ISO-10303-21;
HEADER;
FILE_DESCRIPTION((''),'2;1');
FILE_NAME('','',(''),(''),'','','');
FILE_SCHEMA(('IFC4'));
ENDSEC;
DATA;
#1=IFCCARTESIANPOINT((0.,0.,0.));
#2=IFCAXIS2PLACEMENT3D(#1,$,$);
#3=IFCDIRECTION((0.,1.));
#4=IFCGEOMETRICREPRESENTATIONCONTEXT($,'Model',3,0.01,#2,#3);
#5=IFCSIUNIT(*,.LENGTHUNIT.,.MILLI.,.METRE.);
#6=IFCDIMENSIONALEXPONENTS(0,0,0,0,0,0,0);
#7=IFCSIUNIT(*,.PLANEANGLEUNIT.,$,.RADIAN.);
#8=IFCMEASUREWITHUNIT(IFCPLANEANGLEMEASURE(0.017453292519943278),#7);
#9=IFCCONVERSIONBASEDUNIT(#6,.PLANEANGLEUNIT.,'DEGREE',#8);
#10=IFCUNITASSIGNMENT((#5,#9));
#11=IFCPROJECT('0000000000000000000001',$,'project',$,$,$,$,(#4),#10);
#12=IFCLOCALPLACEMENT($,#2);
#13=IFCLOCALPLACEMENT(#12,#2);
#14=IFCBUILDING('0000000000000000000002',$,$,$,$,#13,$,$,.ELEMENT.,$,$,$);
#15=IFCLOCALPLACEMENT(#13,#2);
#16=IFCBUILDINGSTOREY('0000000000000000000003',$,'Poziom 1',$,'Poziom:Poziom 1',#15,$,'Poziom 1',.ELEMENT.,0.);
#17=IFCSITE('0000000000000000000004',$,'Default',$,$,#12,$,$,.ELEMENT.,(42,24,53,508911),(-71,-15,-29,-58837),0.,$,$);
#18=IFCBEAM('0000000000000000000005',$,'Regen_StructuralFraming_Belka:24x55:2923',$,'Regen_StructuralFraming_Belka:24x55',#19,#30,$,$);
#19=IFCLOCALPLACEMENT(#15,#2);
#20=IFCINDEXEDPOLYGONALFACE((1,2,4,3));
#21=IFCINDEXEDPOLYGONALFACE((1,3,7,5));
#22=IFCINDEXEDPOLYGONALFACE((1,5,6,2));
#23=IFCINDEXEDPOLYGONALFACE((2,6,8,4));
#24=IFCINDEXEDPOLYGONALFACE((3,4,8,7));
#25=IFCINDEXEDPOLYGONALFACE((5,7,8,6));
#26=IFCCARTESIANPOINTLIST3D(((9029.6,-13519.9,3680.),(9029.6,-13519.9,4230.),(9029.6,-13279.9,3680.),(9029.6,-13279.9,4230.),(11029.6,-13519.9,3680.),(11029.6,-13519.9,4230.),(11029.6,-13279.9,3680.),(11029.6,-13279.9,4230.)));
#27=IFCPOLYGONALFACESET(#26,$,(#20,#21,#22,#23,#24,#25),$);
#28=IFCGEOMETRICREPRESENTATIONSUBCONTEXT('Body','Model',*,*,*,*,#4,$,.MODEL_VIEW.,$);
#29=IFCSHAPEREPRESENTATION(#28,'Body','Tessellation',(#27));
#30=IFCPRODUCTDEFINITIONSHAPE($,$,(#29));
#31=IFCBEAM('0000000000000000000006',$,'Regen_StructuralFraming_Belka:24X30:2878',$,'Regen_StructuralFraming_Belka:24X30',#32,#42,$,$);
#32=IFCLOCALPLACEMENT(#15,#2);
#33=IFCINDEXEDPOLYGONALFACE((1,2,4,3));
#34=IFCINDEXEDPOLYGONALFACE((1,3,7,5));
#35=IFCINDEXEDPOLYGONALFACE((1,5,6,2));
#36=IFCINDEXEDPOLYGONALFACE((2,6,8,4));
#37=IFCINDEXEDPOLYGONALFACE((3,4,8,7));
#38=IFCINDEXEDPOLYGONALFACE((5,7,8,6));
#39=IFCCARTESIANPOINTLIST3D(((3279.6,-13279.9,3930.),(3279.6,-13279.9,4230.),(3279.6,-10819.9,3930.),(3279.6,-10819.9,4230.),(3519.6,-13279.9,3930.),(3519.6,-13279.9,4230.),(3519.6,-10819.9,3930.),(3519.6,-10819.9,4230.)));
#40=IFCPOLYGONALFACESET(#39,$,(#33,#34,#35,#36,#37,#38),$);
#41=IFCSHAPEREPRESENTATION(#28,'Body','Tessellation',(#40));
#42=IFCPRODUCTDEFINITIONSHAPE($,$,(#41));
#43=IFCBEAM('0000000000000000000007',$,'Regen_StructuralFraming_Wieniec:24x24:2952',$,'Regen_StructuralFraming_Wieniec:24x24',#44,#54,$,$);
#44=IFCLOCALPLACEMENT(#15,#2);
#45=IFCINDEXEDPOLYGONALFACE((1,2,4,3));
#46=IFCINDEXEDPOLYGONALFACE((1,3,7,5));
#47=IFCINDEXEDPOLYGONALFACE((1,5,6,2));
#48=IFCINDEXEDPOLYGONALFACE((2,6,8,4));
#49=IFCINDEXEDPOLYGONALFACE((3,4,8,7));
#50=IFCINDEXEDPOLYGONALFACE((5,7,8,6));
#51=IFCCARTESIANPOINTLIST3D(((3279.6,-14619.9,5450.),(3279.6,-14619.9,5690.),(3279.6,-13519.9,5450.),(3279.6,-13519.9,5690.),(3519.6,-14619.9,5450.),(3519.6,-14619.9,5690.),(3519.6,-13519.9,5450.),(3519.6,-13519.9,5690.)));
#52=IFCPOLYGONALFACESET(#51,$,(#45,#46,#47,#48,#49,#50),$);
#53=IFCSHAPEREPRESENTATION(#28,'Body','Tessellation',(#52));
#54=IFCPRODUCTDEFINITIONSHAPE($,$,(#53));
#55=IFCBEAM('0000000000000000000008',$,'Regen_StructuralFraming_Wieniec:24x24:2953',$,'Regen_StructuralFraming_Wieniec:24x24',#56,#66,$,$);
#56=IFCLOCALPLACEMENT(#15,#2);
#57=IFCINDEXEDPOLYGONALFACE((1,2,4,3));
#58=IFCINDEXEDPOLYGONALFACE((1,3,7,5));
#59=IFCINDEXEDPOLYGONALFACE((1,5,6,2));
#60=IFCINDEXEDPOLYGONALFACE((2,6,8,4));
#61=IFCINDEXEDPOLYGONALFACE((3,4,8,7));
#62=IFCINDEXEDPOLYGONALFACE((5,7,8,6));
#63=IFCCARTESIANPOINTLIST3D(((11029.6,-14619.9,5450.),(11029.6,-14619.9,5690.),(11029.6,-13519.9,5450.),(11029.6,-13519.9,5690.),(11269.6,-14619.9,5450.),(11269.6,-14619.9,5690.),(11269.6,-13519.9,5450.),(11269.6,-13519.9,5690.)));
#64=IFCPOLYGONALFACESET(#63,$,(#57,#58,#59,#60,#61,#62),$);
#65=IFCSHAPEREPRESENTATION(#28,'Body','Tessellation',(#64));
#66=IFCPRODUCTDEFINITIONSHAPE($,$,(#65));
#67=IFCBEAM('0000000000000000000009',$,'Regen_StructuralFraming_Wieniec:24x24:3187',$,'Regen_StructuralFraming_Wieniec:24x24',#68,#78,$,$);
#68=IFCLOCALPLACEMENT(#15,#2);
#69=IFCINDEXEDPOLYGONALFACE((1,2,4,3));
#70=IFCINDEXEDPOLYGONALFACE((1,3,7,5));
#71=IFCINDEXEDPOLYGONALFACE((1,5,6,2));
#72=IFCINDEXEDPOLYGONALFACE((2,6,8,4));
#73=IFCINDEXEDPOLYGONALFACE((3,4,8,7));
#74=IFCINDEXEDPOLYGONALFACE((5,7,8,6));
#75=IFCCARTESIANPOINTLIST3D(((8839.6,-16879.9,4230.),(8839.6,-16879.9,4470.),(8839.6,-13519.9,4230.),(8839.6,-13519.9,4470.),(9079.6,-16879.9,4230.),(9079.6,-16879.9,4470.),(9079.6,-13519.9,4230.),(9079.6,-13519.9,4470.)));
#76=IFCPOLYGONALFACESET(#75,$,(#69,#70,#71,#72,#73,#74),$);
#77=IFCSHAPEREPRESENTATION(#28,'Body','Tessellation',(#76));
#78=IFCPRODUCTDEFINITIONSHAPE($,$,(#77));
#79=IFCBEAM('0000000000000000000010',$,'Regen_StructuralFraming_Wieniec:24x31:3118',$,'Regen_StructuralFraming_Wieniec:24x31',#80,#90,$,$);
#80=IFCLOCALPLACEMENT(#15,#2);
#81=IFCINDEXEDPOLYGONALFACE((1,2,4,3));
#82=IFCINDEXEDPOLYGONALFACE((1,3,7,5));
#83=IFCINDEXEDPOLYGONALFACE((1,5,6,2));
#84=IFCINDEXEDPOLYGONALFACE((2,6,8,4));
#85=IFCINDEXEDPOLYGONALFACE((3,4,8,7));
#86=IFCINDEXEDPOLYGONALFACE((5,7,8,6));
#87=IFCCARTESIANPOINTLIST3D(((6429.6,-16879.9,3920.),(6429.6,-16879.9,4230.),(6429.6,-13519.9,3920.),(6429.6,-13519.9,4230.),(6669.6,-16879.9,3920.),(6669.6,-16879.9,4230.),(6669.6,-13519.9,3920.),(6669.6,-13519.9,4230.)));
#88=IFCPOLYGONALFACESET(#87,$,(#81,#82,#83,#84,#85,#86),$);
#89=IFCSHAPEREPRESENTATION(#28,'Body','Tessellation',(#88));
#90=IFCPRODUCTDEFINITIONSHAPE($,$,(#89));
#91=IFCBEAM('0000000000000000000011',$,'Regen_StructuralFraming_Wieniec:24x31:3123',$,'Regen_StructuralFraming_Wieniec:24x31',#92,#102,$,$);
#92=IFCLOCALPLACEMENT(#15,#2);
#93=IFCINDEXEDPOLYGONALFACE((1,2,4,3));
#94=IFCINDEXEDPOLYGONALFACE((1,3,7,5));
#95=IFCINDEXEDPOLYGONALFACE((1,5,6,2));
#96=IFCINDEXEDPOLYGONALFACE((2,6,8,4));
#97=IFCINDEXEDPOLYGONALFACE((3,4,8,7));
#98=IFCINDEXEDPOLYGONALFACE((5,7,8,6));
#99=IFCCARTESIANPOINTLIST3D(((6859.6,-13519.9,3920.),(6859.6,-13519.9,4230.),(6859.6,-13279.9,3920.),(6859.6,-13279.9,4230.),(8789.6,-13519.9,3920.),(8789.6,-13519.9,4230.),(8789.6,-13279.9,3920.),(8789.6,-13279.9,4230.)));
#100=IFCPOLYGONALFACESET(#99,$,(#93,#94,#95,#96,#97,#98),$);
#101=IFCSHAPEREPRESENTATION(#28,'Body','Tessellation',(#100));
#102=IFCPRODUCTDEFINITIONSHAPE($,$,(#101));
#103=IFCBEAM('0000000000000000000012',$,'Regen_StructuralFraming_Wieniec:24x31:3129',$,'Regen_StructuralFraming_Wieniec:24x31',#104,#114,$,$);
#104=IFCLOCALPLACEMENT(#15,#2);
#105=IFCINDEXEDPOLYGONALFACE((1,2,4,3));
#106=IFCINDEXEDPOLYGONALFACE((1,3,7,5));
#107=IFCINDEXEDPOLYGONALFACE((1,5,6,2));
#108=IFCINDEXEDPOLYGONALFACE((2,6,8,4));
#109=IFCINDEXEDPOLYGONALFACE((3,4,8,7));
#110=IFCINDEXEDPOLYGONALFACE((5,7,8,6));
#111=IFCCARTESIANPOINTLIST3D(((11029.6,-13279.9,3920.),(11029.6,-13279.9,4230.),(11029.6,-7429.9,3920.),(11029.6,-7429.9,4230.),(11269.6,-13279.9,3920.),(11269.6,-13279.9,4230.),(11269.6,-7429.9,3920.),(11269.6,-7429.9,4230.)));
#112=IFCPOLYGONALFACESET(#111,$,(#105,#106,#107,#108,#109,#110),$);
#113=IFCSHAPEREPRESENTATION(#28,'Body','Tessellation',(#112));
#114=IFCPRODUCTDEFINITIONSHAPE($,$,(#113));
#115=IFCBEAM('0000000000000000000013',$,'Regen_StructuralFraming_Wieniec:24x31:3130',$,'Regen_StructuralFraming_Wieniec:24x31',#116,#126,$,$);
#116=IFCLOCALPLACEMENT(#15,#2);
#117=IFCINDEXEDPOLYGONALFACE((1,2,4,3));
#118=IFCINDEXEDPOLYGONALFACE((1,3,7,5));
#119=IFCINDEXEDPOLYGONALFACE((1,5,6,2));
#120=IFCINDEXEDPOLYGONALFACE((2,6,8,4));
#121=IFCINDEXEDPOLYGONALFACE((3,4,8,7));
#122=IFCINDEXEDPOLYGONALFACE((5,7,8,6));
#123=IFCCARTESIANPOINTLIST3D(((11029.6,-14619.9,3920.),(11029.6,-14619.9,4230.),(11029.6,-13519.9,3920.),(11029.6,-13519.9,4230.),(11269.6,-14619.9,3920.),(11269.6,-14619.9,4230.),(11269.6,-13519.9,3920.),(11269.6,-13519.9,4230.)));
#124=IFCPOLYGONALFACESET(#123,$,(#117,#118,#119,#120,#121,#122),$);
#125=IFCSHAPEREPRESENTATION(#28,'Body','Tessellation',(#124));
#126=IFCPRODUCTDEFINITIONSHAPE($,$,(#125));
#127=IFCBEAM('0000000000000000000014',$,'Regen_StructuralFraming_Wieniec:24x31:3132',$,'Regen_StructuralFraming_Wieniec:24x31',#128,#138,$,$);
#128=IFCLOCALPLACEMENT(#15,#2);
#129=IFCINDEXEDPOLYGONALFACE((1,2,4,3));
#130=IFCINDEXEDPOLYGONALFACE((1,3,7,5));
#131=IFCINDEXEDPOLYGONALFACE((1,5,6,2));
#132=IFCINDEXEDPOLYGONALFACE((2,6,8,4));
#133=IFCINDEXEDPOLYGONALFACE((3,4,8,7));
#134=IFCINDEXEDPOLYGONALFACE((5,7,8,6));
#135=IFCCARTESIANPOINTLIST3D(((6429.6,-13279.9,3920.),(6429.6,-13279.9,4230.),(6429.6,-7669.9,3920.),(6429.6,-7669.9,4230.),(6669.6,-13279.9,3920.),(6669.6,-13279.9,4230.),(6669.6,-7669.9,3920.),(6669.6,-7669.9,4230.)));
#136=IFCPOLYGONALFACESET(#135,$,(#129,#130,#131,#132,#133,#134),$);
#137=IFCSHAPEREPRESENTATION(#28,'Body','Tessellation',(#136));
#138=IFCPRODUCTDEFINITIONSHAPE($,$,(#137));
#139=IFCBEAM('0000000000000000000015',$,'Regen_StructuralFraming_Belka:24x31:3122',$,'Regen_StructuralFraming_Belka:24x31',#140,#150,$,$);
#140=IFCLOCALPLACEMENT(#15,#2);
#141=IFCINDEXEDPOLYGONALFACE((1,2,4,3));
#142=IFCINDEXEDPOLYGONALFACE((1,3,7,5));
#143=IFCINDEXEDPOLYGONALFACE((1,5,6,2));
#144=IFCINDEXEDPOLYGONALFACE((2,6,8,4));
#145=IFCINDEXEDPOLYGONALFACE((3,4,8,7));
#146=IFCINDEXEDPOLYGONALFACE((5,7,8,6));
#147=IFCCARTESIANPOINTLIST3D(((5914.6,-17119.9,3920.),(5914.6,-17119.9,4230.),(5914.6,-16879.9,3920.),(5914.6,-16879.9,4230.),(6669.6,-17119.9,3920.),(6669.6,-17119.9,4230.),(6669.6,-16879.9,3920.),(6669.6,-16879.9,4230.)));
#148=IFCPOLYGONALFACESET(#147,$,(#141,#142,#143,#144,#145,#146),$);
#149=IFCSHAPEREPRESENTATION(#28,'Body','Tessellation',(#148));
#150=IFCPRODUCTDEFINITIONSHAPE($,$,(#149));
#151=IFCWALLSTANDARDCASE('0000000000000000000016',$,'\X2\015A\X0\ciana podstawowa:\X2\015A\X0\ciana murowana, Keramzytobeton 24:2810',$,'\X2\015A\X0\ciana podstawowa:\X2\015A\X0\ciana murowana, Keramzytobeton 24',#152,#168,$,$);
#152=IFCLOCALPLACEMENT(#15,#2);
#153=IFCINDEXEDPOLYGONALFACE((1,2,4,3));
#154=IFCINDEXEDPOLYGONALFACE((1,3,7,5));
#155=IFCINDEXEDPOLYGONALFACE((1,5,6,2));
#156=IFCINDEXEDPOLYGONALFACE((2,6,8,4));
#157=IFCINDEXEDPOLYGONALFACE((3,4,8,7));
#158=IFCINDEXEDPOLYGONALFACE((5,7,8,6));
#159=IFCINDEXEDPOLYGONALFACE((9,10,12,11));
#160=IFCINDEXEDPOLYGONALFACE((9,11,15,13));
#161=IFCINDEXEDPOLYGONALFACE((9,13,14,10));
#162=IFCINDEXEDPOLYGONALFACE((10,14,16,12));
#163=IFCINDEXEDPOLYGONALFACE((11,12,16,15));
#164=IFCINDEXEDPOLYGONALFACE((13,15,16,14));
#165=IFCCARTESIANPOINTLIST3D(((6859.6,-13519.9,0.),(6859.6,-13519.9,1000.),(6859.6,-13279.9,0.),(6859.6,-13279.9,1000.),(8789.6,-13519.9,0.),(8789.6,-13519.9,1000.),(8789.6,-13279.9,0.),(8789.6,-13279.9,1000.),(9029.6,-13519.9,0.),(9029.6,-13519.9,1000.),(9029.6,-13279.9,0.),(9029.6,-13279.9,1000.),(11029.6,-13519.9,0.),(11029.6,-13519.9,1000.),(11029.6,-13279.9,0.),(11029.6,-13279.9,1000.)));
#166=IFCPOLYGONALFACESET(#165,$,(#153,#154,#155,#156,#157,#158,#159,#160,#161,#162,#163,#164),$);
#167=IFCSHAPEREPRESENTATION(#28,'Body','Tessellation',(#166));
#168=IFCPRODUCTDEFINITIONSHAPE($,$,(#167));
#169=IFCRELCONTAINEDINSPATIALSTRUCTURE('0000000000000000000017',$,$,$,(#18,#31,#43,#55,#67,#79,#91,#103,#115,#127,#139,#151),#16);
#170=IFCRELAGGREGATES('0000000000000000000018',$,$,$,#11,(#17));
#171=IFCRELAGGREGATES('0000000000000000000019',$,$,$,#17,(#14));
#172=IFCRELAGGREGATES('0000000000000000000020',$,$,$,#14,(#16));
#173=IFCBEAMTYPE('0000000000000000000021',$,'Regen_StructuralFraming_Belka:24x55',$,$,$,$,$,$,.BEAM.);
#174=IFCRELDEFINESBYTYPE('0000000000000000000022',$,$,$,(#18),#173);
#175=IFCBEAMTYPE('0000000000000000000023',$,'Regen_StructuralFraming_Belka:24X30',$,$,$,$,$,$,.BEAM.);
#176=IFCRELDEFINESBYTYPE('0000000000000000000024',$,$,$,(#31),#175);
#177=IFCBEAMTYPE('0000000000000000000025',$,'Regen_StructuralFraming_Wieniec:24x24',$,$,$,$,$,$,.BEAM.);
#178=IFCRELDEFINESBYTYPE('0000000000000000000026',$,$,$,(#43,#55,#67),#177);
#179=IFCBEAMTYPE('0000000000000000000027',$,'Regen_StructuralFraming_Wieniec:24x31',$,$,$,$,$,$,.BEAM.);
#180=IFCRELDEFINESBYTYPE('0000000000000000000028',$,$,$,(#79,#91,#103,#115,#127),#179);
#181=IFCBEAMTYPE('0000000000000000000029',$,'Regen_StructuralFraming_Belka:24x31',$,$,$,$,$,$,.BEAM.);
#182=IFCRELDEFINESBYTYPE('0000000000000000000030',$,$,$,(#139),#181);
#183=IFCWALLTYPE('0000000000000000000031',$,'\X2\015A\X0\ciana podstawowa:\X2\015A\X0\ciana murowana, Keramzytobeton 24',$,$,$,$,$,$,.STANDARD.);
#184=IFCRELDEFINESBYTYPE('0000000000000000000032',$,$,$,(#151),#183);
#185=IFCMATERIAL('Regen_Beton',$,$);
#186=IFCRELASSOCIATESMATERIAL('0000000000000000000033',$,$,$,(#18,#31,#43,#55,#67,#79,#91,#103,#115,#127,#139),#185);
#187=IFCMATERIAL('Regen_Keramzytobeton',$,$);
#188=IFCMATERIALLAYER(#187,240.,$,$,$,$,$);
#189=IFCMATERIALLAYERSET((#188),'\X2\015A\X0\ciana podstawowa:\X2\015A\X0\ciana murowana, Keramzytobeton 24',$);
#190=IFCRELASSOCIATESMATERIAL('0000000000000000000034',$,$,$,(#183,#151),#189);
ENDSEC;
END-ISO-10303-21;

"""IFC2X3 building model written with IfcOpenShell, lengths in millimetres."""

from ifc_helpers import new_model, entity, si_unit, converted_unit, direction, frame, frame_2d, origin, origin_2d_with_axis, place, context, subcontext, project, spatial, rectangle, extrude, material, layer, layer_set, layer_usage, type_object, element, save


model = new_model("IFC2X3")

# Units and contexts
model_context = context("Model", 3, precision=0.01, world=origin(), true_north=direction((0.0, 1.0)))
body_context = subcontext(model_context, "Body", "Model", "MODEL_VIEW")
ifc_project = project(units=[si_unit("LENGTHUNIT", "METRE", prefix="MILLI"), converted_unit("PLANEANGLEUNIT", "DEGREE", entity("IfcPlaneAngleMeasure", 0.017453292519943278), si_unit("PLANEANGLEUNIT", "RADIAN"), dimensions=[0, 0, 0, 0, 0, 0, 0])], contexts=[model_context])

# Site, building, storey
site_placement = place(None, origin())
site = spatial("IfcSite", under=ifc_project, at=site_placement, Name="Default", CompositionType="ELEMENT", RefLatitude=(42, 24, 53, 508911), RefLongitude=(-71, -15, -29, -58837), RefElevation=0.0)
building_placement = place(site_placement, origin())
building = spatial("IfcBuilding", under=site, at=building_placement, CompositionType="ELEMENT")
storey_placement = place(building_placement, origin())
storey = spatial("IfcBuildingStorey", under=building, at=storey_placement, Name="Poziom 1", ObjectType="Poziom:Poziom 1", LongName="Poziom 1", CompositionType="ELEMENT", Elevation=0.0)

# Beams
ifc_material_1 = material(Name="Regen_Beton")
beam_type_1 = type_object("IfcBeamType", Name="Regen_StructuralFraming_Belka:24x55", PredefinedType="BEAM")
beam_1_placement = place(storey_placement, frame((9029.6, -13399.9, 4230.0)))
element("IfcBeam", 1, at=beam_1_placement, inside=storey, type_object=beam_type_1, material=ifc_material_1, Name="Regen_StructuralFraming_Belka:24x55:2923", ObjectType="Regen_StructuralFraming_Belka:24x55", context=body_context, shape_type="SweptSolid", body=[
    extrude(rectangle(XDim=550.0, YDim=240.0, at=frame_2d((0.0, 0.0), x_axis=(1.0, 0.0))), frame((0.0, 0.0, -275.0), z_axis=(1.0, 0.0, 0.0), x_axis=(0.0, 0.0, -1.0)), (0.0, 0.0, 1.0), 2000.0),
])
beam_type_2 = type_object("IfcBeamType", Name="Regen_StructuralFraming_Belka:24X30", PredefinedType="BEAM")
beam_2_placement = place(storey_placement, frame((3399.6, -13279.9, 4230.0), z_axis=(0.0, 0.0, 1.0), x_axis=(0.0, 1.0, 0.0)))
element("IfcBeam", 2, at=beam_2_placement, inside=storey, type_object=beam_type_2, material=ifc_material_1, Name="Regen_StructuralFraming_Belka:24X30:2878", ObjectType="Regen_StructuralFraming_Belka:24X30", context=body_context, shape_type="SweptSolid", body=[
    extrude(rectangle(XDim=300.0, YDim=240.0, at=frame_2d((0.0, 0.0), x_axis=(1.0, 0.0))), frame((0.0, 0.0, -150.0), z_axis=(1.0, 0.0, 0.0), x_axis=(0.0, 0.0, -1.0)), (0.0, 0.0, 1.0), 2460.0),
])
beam_type_3 = type_object("IfcBeamType", Name="Regen_StructuralFraming_Wieniec:24x24", PredefinedType="BEAM")
beam_3_placement = place(storey_placement, frame((3399.6, -14619.9, 5690.0), z_axis=(0.0, 0.0, 1.0), x_axis=(0.0, 1.0, 0.0)))
element("IfcBeam", 3, at=beam_3_placement, inside=storey, type_object=beam_type_3, material=ifc_material_1, Name="Regen_StructuralFraming_Wieniec:24x24:2952", ObjectType="Regen_StructuralFraming_Wieniec:24x24", context=body_context, shape_type="SweptSolid", body=[
    extrude(rectangle(XDim=240.0, YDim=240.0, at=frame_2d((0.0, 0.0), x_axis=(1.0, 0.0))), frame((0.0, 0.0, -120.0), z_axis=(1.0, 0.0, 0.0), x_axis=(0.0, 0.0, -1.0)), (0.0, 0.0, 1.0), 1100.0),
])
beam_4_placement = place(storey_placement, frame((11149.6, -14619.9, 5690.0), z_axis=(0.0, 0.0, 1.0), x_axis=(0.0, 1.0, 0.0)))
element("IfcBeam", 4, at=beam_4_placement, inside=storey, type_object=beam_type_3, material=ifc_material_1, Name="Regen_StructuralFraming_Wieniec:24x24:2953", ObjectType="Regen_StructuralFraming_Wieniec:24x24", context=body_context, shape_type="SweptSolid", body=[
    extrude(rectangle(XDim=240.0, YDim=240.0, at=origin_2d_with_axis()), frame((0.0, 0.0, -120.0), z_axis=(1.0, 0.0, 0.0), x_axis=(0.0, 0.0, -1.0)), (0.0, 0.0, 1.0), 1100.0),
])
beam_5_placement = place(storey_placement, frame((8959.6, -16999.9, 4230.0), z_axis=(0.0, 0.0, 1.0), x_axis=(0.0, 1.0, 0.0)))
element("IfcBeam", 5, at=beam_5_placement, inside=storey, type_object=beam_type_3, material=ifc_material_1, Name="Regen_StructuralFraming_Wieniec:24x24:3187", ObjectType="Regen_StructuralFraming_Wieniec:24x24", context=body_context, shape_type="SweptSolid", body=[
    extrude(rectangle(XDim=240.0, YDim=240.0, at=frame_2d((0.0, 0.0), x_axis=(1.0, 0.0))), frame((120.0, 0.0, 120.0), z_axis=(1.0, 0.0, 0.0), x_axis=(0.0, 0.0, -1.0)), (0.0, 0.0, 1.0), 3360.0),
])
beam_type_4 = type_object("IfcBeamType", Name="Regen_StructuralFraming_Wieniec:24x31", PredefinedType="BEAM")
beam_6_placement = place(storey_placement, frame((6549.6, -16879.9, 4230.0), z_axis=(0.0, 0.0, 1.0), x_axis=(0.0, 1.0, 0.0)))
element("IfcBeam", 6, at=beam_6_placement, inside=storey, type_object=beam_type_4, material=ifc_material_1, Name="Regen_StructuralFraming_Wieniec:24x31:3118", ObjectType="Regen_StructuralFraming_Wieniec:24x31", context=body_context, shape_type="SweptSolid", body=[
    extrude(rectangle(XDim=310.0, YDim=240.0, at=frame_2d((0.0, 0.0), x_axis=(1.0, 0.0))), frame((0.0, 0.0, -155.0), z_axis=(1.0, 0.0, 0.0), x_axis=(0.0, 0.0, -1.0)), (0.0, 0.0, 1.0), 3360.0),
])
beam_7_placement = place(storey_placement, frame((8789.6, -13399.9, 4230.0), z_axis=(0.0, 0.0, 1.0), x_axis=(-1.0, 0.0, 0.0)))
element("IfcBeam", 7, at=beam_7_placement, inside=storey, type_object=beam_type_4, material=ifc_material_1, Name="Regen_StructuralFraming_Wieniec:24x31:3123", ObjectType="Regen_StructuralFraming_Wieniec:24x31", context=body_context, shape_type="SweptSolid", body=[
    extrude(rectangle(XDim=310.0, YDim=240.0, at=frame_2d((0.0, 0.0), x_axis=(1.0, 0.0))), frame((0.0, 0.0, -155.0), z_axis=(1.0, 0.0, 0.0), x_axis=(0.0, 0.0, -1.0)), (0.0, 0.0, 1.0), 1930.0),
])
beam_8_placement = place(storey_placement, frame((11149.6, -13279.9, 4230.0), z_axis=(0.0, 0.0, 1.0), x_axis=(0.0, 1.0, 0.0)))
element("IfcBeam", 8, at=beam_8_placement, inside=storey, type_object=beam_type_4, material=ifc_material_1, Name="Regen_StructuralFraming_Wieniec:24x31:3129", ObjectType="Regen_StructuralFraming_Wieniec:24x31", context=body_context, shape_type="SweptSolid", body=[
    extrude(rectangle(XDim=310.0, YDim=240.0, at=frame_2d((0.0, 0.0), x_axis=(1.0, 0.0))), frame((0.0, 0.0, -155.0), z_axis=(1.0, 0.0, 0.0), x_axis=(0.0, 0.0, -1.0)), (0.0, 0.0, 1.0), 5850.0),
])
beam_9_placement = place(storey_placement, frame((11149.6, -14619.9, 4230.0), z_axis=(0.0, 0.0, 1.0), x_axis=(0.0, 1.0, 0.0)))
element("IfcBeam", 9, at=beam_9_placement, inside=storey, type_object=beam_type_4, material=ifc_material_1, Name="Regen_StructuralFraming_Wieniec:24x31:3130", ObjectType="Regen_StructuralFraming_Wieniec:24x31", context=body_context, shape_type="SweptSolid", body=[
    extrude(rectangle(XDim=310.0, YDim=240.0, at=frame_2d((0.0, 0.0), x_axis=(1.0, 0.0))), frame((0.0, 0.0, -155.0), z_axis=(1.0, 0.0, 0.0), x_axis=(0.0, 0.0, -1.0)), (0.0, 0.0, 1.0), 1100.0),
])
beam_10_placement = place(storey_placement, frame((6549.6, -13279.9, 4230.0), z_axis=(0.0, 0.0, 1.0), x_axis=(0.0, 1.0, 0.0)))
element("IfcBeam", 10, at=beam_10_placement, inside=storey, type_object=beam_type_4, material=ifc_material_1, Name="Regen_StructuralFraming_Wieniec:24x31:3132", ObjectType="Regen_StructuralFraming_Wieniec:24x31", context=body_context, shape_type="SweptSolid", body=[
    extrude(rectangle(XDim=310.0, YDim=240.0, at=frame_2d((0.0, 0.0), x_axis=(1.0, 0.0))), frame((0.0, 0.0, -155.0), z_axis=(1.0, 0.0, 0.0), x_axis=(0.0, 0.0, -1.0)), (0.0, 0.0, 1.0), 5610.0),
])
beam_type_5 = type_object("IfcBeamType", Name="Regen_StructuralFraming_Belka:24x31", PredefinedType="BEAM")
beam_11_placement = place(storey_placement, frame((6669.6, -16999.9, 4230.0), z_axis=(0.0, 0.0, 1.0), x_axis=(-1.0, 0.0, 0.0)))
element("IfcBeam", 11, at=beam_11_placement, inside=storey, type_object=beam_type_5, material=ifc_material_1, Name="Regen_StructuralFraming_Belka:24x31:3122", ObjectType="Regen_StructuralFraming_Belka:24x31", context=body_context, shape_type="SweptSolid", body=[
    extrude(rectangle(XDim=310.0, YDim=240.0, at=frame_2d((0.0, 0.0), x_axis=(1.0, 0.0))), frame((0.0, 0.0, -155.0), z_axis=(1.0, 0.0, 0.0), x_axis=(0.0, 0.0, -1.0)), (0.0, 0.0, 1.0), 755.0),
])

# Wall, opening
ifc_material_2 = material(Name="Regen_Keramzytobeton")
ifc_layer_1 = layer(ifc_material_2, 240.0)
ifc_layer_set_1 = layer_set([ifc_layer_1], Name="Ściana podstawowa:Ściana murowana, Keramzytobeton 24")
ifc_layer_usage_1 = layer_usage(ifc_layer_set_1, "AXIS2", "NEGATIVE", 120.0)
wall_type_1 = type_object("IfcWallType", Name="Ściana podstawowa:Ściana murowana, Keramzytobeton 24", PredefinedType="STANDARD", material=ifc_layer_set_1)
wall_1_placement = place(storey_placement, frame((11029.6, -13399.9, 0.0), z_axis=(0.0, 0.0, 1.0), x_axis=(-1.0, 0.0, 0.0)))
wall_1 = element("IfcWallStandardCase", 12, at=wall_1_placement, inside=storey, type_object=wall_type_1, material=ifc_layer_usage_1, Name="Ściana podstawowa:Ściana murowana, Keramzytobeton 24:2810", ObjectType="Ściana podstawowa:Ściana murowana, Keramzytobeton 24", context=body_context, shape_type="SweptSolid", body=[
    extrude(rectangle(XDim=4170.0, YDim=240.0, at=frame_2d((2085.0, 0.0), x_axis=(-1.0, 0.0))), origin(), (0.0, 0.0, 1.0), 1000.0),
])
opening_1_placement = place(storey_placement, frame((11029.6, -13399.9, 0.0), z_axis=(0.0, 0.0, 1.0), x_axis=(-1.0, 0.0, 0.0)))
element("IfcOpeningElement", 13, at=opening_1_placement, cuts=wall_1, ObjectType="Opening", context=body_context, shape_type="SweptSolid", body=[
    extrude(rectangle(XDim=1000.0, YDim=240.0, at=frame_2d((0.0, 0.0), x_axis=(1.0, 0.0))), frame((2240.0, 0.0, 500.0), z_axis=(-1.0, 0.0, 0.0), x_axis=(0.0, 0.0, 1.0)), (0.0, 0.0, 1.0), 240.0),
])

save(model, "model.ifc")
